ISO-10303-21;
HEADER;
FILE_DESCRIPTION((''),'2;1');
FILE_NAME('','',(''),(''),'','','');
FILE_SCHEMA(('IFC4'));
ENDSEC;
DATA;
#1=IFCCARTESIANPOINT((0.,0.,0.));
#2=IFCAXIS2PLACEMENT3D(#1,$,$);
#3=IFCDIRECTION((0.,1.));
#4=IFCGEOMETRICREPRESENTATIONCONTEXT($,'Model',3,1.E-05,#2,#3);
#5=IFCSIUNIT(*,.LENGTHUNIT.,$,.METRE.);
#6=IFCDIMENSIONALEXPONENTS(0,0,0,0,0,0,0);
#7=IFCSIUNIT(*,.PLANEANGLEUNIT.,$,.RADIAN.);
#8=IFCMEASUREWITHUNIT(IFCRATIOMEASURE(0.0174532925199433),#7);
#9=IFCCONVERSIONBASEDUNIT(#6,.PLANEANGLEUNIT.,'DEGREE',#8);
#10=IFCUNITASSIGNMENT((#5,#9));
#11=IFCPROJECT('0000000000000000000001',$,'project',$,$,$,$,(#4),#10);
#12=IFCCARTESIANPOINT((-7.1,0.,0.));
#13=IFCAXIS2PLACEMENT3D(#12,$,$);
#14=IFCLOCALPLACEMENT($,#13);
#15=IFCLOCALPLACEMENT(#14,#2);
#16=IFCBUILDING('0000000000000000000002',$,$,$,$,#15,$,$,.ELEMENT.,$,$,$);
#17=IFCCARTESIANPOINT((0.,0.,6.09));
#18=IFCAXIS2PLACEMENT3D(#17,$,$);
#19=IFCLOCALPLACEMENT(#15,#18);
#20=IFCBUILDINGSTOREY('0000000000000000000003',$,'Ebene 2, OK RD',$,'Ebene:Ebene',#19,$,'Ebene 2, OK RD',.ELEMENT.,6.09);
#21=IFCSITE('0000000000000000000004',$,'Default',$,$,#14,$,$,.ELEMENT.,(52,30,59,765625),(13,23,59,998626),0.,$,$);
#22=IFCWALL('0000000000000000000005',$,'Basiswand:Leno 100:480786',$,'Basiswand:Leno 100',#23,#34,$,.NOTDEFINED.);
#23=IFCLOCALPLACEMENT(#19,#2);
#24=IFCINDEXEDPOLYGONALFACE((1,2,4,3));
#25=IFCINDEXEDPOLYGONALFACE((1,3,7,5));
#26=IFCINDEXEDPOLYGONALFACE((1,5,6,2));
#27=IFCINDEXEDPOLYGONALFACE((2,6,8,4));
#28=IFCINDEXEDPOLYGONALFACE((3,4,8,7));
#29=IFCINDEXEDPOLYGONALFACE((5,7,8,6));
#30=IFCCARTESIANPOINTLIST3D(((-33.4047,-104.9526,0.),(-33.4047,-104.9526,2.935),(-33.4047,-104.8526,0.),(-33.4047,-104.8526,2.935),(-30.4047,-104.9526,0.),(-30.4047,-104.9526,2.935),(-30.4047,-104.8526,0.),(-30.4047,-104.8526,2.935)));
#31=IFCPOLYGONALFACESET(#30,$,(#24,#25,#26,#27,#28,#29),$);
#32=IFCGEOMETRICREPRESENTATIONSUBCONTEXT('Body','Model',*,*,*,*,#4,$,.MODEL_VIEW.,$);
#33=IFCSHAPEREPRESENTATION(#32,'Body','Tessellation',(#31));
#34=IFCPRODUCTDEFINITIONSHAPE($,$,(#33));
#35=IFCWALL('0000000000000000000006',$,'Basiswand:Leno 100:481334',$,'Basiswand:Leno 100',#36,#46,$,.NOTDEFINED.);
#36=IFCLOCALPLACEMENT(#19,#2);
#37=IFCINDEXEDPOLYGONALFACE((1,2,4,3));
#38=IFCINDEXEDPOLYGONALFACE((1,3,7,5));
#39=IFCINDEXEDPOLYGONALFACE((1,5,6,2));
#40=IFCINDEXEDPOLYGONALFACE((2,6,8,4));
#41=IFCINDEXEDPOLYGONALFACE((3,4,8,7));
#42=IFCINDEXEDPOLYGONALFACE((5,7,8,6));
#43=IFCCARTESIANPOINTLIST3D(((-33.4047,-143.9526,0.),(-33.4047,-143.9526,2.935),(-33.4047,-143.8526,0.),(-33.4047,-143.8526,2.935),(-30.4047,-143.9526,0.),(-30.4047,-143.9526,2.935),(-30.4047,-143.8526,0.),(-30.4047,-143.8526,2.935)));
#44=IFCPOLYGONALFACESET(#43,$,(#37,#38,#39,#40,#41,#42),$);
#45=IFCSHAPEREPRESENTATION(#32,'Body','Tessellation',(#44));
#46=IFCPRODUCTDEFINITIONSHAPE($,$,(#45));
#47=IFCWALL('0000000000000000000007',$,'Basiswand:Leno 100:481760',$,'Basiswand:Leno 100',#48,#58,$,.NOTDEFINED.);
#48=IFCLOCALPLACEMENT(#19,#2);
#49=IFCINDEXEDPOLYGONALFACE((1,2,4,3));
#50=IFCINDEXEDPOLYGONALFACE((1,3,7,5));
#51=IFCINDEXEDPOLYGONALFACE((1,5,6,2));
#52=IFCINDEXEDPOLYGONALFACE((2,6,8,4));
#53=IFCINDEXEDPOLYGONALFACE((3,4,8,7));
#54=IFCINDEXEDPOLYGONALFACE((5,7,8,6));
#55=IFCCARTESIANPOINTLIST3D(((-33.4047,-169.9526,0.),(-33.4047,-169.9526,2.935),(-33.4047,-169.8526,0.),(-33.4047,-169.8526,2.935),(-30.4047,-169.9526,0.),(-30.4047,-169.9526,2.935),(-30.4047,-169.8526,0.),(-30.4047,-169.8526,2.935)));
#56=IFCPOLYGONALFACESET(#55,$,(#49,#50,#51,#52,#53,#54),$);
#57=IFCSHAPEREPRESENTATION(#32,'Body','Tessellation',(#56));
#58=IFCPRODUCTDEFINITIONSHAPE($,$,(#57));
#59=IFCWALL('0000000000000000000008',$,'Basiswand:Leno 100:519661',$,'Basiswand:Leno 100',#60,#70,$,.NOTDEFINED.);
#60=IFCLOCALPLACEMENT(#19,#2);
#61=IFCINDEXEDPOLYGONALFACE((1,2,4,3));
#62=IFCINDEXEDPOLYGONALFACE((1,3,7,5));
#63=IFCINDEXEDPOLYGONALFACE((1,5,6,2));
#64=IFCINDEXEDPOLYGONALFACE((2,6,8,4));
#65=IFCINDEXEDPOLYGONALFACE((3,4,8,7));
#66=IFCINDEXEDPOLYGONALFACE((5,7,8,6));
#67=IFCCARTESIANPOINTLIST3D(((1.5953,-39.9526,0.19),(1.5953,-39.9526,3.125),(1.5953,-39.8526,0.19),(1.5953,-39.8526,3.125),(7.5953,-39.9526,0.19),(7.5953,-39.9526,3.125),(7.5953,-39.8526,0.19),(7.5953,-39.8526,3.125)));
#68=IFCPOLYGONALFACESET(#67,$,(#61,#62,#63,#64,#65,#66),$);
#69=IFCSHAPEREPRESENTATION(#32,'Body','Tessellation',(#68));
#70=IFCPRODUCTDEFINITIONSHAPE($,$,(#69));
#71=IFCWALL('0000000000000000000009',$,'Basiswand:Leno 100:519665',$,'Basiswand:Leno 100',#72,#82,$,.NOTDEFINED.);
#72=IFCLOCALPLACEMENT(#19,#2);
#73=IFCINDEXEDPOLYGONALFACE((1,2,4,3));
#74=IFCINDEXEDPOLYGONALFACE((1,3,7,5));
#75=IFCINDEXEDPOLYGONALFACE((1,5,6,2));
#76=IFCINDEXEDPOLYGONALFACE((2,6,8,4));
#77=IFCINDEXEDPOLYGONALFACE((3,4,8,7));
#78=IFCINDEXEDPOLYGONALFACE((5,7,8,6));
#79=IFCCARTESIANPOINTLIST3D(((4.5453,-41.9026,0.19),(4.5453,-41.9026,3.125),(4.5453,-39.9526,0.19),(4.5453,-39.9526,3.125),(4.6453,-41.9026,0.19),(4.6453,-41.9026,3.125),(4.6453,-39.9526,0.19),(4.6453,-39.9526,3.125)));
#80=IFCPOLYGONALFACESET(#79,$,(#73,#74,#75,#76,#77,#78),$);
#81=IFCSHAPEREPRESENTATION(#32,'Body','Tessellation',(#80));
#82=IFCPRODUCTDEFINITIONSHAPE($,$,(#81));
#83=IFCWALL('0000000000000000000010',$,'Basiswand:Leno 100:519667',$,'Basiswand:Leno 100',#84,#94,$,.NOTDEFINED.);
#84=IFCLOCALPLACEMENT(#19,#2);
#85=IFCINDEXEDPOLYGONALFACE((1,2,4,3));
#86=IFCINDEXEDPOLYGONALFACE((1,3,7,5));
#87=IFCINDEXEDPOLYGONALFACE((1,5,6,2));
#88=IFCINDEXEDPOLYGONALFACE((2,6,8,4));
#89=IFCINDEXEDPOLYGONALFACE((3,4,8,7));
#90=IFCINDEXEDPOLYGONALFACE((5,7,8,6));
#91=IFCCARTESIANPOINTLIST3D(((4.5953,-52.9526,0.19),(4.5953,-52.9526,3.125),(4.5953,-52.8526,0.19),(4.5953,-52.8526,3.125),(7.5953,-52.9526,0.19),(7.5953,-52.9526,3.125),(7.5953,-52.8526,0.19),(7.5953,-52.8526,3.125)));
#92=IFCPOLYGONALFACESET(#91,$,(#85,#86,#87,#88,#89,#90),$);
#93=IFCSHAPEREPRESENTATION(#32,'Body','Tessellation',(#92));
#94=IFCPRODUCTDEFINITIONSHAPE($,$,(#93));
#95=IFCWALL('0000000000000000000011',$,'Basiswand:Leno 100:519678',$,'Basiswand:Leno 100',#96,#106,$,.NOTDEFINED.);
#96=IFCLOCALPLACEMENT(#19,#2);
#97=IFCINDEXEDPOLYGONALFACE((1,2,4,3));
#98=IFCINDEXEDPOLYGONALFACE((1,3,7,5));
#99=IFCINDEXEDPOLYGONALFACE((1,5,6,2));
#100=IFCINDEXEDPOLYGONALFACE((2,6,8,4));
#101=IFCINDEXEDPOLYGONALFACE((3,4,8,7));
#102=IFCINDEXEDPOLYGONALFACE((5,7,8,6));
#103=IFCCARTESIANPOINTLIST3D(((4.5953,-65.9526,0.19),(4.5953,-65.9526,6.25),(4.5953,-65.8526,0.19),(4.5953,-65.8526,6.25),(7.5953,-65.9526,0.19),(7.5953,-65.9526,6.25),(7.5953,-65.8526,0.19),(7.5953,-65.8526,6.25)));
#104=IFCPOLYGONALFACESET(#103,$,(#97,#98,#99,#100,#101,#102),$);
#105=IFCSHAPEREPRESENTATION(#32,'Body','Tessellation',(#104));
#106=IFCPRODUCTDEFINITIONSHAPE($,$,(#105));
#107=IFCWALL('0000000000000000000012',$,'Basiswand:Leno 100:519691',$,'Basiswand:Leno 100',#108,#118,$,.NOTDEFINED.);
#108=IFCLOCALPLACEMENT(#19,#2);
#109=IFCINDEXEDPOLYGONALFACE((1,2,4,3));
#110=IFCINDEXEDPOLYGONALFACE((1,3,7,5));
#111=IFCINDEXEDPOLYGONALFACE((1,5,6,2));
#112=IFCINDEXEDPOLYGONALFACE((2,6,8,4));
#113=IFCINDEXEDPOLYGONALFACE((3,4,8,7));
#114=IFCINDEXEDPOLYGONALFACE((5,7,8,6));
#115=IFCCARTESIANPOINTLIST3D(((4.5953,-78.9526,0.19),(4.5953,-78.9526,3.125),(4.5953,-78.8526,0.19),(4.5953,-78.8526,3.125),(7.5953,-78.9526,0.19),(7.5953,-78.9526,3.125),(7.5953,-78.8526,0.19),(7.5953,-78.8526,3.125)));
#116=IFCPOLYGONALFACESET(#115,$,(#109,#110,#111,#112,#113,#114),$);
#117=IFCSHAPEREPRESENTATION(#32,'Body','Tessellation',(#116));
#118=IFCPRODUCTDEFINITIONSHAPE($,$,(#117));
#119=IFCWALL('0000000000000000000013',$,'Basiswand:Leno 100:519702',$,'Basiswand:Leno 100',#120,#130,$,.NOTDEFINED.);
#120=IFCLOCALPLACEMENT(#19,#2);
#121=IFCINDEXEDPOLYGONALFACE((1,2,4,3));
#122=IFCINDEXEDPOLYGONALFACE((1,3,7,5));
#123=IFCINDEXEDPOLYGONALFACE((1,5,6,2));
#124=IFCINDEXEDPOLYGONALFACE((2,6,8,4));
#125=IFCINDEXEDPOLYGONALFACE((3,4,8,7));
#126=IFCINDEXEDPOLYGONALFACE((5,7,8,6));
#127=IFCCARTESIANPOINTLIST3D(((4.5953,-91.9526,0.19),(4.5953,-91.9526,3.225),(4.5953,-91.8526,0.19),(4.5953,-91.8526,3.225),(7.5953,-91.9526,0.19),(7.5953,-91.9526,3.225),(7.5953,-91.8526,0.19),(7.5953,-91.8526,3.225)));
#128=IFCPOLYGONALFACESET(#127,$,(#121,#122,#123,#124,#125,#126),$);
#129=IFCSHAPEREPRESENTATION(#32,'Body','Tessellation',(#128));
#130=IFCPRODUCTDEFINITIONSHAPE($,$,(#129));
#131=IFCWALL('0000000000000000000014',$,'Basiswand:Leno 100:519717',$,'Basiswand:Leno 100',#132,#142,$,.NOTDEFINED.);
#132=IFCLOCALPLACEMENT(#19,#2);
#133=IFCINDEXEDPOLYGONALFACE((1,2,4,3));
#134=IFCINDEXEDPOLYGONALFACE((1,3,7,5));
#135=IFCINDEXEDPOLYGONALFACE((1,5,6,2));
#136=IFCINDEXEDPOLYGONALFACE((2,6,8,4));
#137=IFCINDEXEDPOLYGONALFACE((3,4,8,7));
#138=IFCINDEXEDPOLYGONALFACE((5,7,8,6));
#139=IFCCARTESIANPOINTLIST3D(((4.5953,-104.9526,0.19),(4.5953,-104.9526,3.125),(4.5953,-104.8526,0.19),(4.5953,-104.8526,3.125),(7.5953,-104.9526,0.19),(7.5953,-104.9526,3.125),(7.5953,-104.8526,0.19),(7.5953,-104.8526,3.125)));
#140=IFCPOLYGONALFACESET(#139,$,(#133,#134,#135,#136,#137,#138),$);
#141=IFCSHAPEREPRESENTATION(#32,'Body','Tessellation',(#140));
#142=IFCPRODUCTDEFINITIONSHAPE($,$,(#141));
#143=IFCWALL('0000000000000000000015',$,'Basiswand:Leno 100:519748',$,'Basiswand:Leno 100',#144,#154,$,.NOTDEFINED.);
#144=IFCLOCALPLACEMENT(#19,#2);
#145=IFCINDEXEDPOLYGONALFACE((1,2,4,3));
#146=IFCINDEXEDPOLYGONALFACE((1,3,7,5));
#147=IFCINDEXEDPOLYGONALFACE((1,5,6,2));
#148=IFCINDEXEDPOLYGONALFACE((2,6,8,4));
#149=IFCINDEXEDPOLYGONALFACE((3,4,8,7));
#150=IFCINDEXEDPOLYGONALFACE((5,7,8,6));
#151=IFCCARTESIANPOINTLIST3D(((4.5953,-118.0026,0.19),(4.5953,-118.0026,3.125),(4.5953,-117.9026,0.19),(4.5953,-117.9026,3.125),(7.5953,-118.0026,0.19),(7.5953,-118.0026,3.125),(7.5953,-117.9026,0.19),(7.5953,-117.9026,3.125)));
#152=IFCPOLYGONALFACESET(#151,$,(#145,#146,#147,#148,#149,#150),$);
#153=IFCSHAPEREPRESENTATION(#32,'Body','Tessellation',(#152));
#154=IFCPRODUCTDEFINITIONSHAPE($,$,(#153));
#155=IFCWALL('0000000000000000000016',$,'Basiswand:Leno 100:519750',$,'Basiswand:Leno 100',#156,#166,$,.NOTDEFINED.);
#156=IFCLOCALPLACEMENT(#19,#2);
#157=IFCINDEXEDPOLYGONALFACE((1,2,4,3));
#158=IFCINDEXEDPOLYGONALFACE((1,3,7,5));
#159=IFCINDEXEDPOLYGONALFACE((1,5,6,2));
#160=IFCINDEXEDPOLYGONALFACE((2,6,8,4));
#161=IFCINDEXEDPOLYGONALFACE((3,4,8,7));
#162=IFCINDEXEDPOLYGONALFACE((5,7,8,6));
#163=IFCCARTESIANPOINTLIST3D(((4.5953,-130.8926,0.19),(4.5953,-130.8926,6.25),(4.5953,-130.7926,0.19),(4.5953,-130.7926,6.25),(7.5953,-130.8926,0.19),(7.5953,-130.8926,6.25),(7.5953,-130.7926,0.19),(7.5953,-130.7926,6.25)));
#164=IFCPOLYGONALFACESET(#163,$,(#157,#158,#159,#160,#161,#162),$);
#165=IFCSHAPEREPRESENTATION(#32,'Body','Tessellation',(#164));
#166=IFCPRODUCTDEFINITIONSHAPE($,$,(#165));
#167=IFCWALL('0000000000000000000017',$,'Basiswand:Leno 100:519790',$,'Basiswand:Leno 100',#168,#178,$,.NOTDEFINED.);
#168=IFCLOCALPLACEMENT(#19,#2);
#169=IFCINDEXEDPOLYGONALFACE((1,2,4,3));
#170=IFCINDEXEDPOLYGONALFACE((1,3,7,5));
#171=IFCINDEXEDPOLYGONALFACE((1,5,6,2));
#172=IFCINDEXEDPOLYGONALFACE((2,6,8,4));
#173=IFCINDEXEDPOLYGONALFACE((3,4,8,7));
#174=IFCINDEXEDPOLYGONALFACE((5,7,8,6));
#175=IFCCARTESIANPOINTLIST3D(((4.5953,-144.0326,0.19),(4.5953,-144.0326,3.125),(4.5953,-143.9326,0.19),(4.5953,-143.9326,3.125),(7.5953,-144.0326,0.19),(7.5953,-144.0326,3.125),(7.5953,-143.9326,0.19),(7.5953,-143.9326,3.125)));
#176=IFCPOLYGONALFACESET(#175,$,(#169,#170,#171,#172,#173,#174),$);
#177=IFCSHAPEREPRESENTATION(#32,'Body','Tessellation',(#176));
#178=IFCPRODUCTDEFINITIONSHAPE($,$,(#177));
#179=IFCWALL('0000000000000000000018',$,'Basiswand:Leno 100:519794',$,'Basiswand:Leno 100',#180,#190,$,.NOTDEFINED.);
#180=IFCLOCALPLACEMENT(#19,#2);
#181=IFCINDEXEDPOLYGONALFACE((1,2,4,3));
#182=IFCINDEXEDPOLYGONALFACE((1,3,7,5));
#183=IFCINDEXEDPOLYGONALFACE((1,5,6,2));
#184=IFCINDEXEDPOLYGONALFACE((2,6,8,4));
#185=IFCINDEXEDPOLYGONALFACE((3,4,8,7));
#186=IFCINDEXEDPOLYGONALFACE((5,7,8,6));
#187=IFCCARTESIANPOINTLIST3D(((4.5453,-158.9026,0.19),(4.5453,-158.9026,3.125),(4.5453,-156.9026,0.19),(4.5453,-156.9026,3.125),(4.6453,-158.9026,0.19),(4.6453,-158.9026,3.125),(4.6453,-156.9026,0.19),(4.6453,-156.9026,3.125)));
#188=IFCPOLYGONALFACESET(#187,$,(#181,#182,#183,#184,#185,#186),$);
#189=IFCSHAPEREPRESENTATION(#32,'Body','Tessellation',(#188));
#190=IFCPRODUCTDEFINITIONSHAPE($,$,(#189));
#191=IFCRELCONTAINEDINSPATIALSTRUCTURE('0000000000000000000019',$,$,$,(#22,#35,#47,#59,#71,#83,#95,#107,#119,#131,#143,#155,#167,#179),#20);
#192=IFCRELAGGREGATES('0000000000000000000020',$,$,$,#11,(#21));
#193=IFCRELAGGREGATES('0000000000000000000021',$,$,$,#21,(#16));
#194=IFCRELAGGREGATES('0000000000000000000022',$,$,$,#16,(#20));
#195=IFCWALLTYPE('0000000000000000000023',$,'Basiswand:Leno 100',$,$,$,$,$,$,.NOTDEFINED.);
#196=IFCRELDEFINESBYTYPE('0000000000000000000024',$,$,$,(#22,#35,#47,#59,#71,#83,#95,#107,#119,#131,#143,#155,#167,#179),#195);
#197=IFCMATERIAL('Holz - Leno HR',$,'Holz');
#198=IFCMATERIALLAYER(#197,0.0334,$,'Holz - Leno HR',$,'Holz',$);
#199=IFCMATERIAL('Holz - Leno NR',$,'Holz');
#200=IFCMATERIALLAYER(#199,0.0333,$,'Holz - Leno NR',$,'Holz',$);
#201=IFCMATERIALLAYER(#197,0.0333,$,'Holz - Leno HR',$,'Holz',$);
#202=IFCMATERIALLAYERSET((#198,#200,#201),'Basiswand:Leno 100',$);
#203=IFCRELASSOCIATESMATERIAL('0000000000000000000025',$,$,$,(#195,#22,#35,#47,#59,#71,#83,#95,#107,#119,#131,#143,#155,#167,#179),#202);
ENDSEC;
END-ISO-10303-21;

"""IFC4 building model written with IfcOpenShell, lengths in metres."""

from ifc_helpers import new_model, entity, si_unit, converted_unit, direction, frame, origin, place, context, subcontext, project, spatial, indexed_curve, outline, extrude, material, layer, layer_set, type_object, element, save


model = new_model("IFC4")

# Units and contexts
model_context = context("Model", 3, precision=1e-05, world=origin(), true_north=direction((0.0, 1.0)))
body_context = subcontext(model_context, "Body", "Model", "MODEL_VIEW")
ifc_project = project(units=[si_unit("LENGTHUNIT", "METRE"), converted_unit("PLANEANGLEUNIT", "DEGREE", entity("IfcRatioMeasure", 0.0174532925199433), si_unit("PLANEANGLEUNIT", "RADIAN"), dimensions=[0, 0, 0, 0, 0, 0, 0])], contexts=[model_context])

# Site, building, storey
site_placement = place(None, frame((-7.1, 0.0, 0.0)))
site = spatial("IfcSite", under=ifc_project, at=site_placement, Name="Default", CompositionType="ELEMENT", RefLatitude=(52, 30, 59, 765625), RefLongitude=(13, 23, 59, 998626), RefElevation=0.0)
building_placement = place(site_placement, origin())
building = spatial("IfcBuilding", under=site, at=building_placement, CompositionType="ELEMENT")
storey_placement = place(building_placement, frame((0.0, 0.0, 6.09)))
storey = spatial("IfcBuildingStorey", under=building, at=storey_placement, Name="Ebene 2, OK RD", ObjectType="Ebene:Ebene", LongName="Ebene 2, OK RD", CompositionType="ELEMENT", Elevation=6.09)

# Walls
ifc_material_1 = material(Name="Holz - Leno HR", Category="Holz")
ifc_layer_1 = layer(ifc_material_1, 0.0334, Name="Holz - Leno HR", Category="Holz")
ifc_material_2 = material(Name="Holz - Leno NR", Category="Holz")
ifc_layer_2 = layer(ifc_material_2, 0.0333, Name="Holz - Leno NR", Category="Holz")
ifc_layer_3 = layer(ifc_material_1, 0.0333, Name="Holz - Leno HR", Category="Holz")
ifc_layer_set = layer_set([ifc_layer_1, ifc_layer_2, ifc_layer_3], Name="Basiswand:Leno 100")
wall_type = type_object("IfcWallType", Name="Basiswand:Leno 100", PredefinedType="NOTDEFINED", material=ifc_layer_set)
for number, where, z_axis, x_axis, name in (
    (1, (-30.4047, -104.9026, 0.0), (0.0, 0.0, 1.0), (-1.0, 0.0, 0.0), "Basiswand:Leno 100:480786"),
    (2, (-30.4047, -143.9026, 0.0), (0.0, 0.0, 1.0), (-1.0, 0.0, 0.0), "Basiswand:Leno 100:481334"),
):
    element("IfcWall", number, at=place(storey_placement, frame(where, z_axis=z_axis, x_axis=x_axis)), inside=storey, type_object=wall_type, material=ifc_layer_set, Name=name, ObjectType="Basiswand:Leno 100", PredefinedType="NOTDEFINED", context=body_context, shape_type="SweptSolid", body=[
        extrude(outline(indexed_curve([(3.0, 0.05), (0.0, 0.05), (0.0, -0.05), (3.0, -0.05), (3.0, 0.05)], self_intersect=False)), origin(), (0.0, 0.0, 1.0), 2.935),
    ])
wall_1_placement = place(storey_placement, frame((-30.4047, -169.9026, 0.0), z_axis=(0.0, 0.0, 1.0), x_axis=(-1.0, 0.0, 0.0)))
element("IfcWall", 3, at=wall_1_placement, inside=storey, type_object=wall_type, material=ifc_layer_set, Name="Basiswand:Leno 100:481760", ObjectType="Basiswand:Leno 100", PredefinedType="NOTDEFINED", context=body_context, shape_type="SweptSolid", body=[
    extrude(outline(indexed_curve([(3.0, 0.05), (0.0, 0.05), (0.0, -0.05), (3.0, -0.05), (3.0, 0.05)], self_intersect=False)), origin(), (0.0, 0.0, 1.0), 2.935),
])
wall_2_placement = place(storey_placement, frame((1.5953, -39.9026, 0.19)))
element("IfcWall", 4, at=wall_2_placement, inside=storey, type_object=wall_type, material=ifc_layer_set, Name="Basiswand:Leno 100:519661", ObjectType="Basiswand:Leno 100", PredefinedType="NOTDEFINED", context=body_context, shape_type="SweptSolid", body=[
    extrude(outline(indexed_curve([(6.0, 0.05), (0.0, 0.05), (0.0, -0.05), (6.0, -0.05), (6.0, 0.05)], self_intersect=False)), origin(), (0.0, 0.0, 1.0), 2.935),
])
wall_3_placement = place(storey_placement, frame((4.5953, -41.9026, 0.19), z_axis=(0.0, 0.0, 1.0), x_axis=(0.0, 1.0, 0.0)))
element("IfcWall", 5, at=wall_3_placement, inside=storey, type_object=wall_type, material=ifc_layer_set, Name="Basiswand:Leno 100:519665", ObjectType="Basiswand:Leno 100", PredefinedType="NOTDEFINED", context=body_context, shape_type="SweptSolid", body=[
    extrude(outline(indexed_curve([(1.95, 0.05), (0.0, 0.05), (0.0, -0.05), (1.95, -0.05), (1.95, 0.05)], self_intersect=False)), origin(), (0.0, 0.0, 1.0), 2.935),
])
wall_4_placement = place(storey_placement, frame((7.5953, -52.9026, 0.19), z_axis=(0.0, 0.0, 1.0), x_axis=(-1.0, 0.0, 0.0)))
element("IfcWall", 6, at=wall_4_placement, inside=storey, type_object=wall_type, material=ifc_layer_set, Name="Basiswand:Leno 100:519667", ObjectType="Basiswand:Leno 100", PredefinedType="NOTDEFINED", context=body_context, shape_type="SweptSolid", body=[
    extrude(outline(indexed_curve([(3.0, 0.05), (0.0, 0.05), (0.0, -0.05), (3.0, -0.05), (3.0, 0.05)], self_intersect=False)), origin(), (0.0, 0.0, 1.0), 2.935),
])
wall_5_placement = place(storey_placement, frame((7.5953, -65.9026, 0.19), z_axis=(0.0, 0.0, 1.0), x_axis=(-1.0, 0.0, 0.0)))
element("IfcWall", 7, at=wall_5_placement, inside=storey, type_object=wall_type, material=ifc_layer_set, Name="Basiswand:Leno 100:519678", ObjectType="Basiswand:Leno 100", PredefinedType="NOTDEFINED", context=body_context, shape_type="SweptSolid", body=[
    extrude(outline(indexed_curve([(3.0, 0.05), (0.0, 0.05), (0.0, -0.05), (3.0, -0.05), (3.0, 0.05)], self_intersect=False)), origin(), (0.0, 0.0, 1.0), 6.06),
])
wall_6_placement = place(storey_placement, frame((7.5953, -78.9026, 0.19), z_axis=(0.0, 0.0, 1.0), x_axis=(-1.0, 0.0, 0.0)))
element("IfcWall", 8, at=wall_6_placement, inside=storey, type_object=wall_type, material=ifc_layer_set, Name="Basiswand:Leno 100:519691", ObjectType="Basiswand:Leno 100", PredefinedType="NOTDEFINED", context=body_context, shape_type="SweptSolid", body=[
    extrude(outline(indexed_curve([(3.0, 0.05), (0.0, 0.05), (0.0, -0.05), (3.0, -0.05), (3.0, 0.05)], self_intersect=False)), origin(), (0.0, 0.0, 1.0), 2.935),
])
wall_7_placement = place(storey_placement, frame((7.5953, -91.9026, 0.19), z_axis=(0.0, 0.0, 1.0), x_axis=(-1.0, 0.0, 0.0)))
element("IfcWall", 9, at=wall_7_placement, inside=storey, type_object=wall_type, material=ifc_layer_set, Name="Basiswand:Leno 100:519702", ObjectType="Basiswand:Leno 100", PredefinedType="NOTDEFINED", context=body_context, shape_type="SweptSolid", body=[
    extrude(outline(indexed_curve([(3.0, 0.05), (0.0, 0.05), (0.0, -0.05), (3.0, -0.05), (3.0, 0.05)], self_intersect=False)), origin(), (0.0, 0.0, 1.0), 3.035),
])
for number, where, z_axis, x_axis, name in (
    (10, (7.5953, -104.9026, 0.19), (0.0, 0.0, 1.0), (-1.0, 0.0, 0.0), "Basiswand:Leno 100:519717"),
    (11, (7.5953, -117.9526, 0.19), (0.0, 0.0, 1.0), (-1.0, 0.0, 0.0), "Basiswand:Leno 100:519748"),
):
    element("IfcWall", number, at=place(storey_placement, frame(where, z_axis=z_axis, x_axis=x_axis)), inside=storey, type_object=wall_type, material=ifc_layer_set, Name=name, ObjectType="Basiswand:Leno 100", PredefinedType="NOTDEFINED", context=body_context, shape_type="SweptSolid", body=[
        extrude(outline(indexed_curve([(3.0, 0.05), (0.0, 0.05), (0.0, -0.05), (3.0, -0.05), (3.0, 0.05)], self_intersect=False)), origin(), (0.0, 0.0, 1.0), 2.935),
    ])
wall_8_placement = place(storey_placement, frame((7.5953, -130.8426, 0.19), z_axis=(0.0, 0.0, 1.0), x_axis=(-1.0, 0.0, 0.0)))
element("IfcWall", 12, at=wall_8_placement, inside=storey, type_object=wall_type, material=ifc_layer_set, Name="Basiswand:Leno 100:519750", ObjectType="Basiswand:Leno 100", PredefinedType="NOTDEFINED", context=body_context, shape_type="SweptSolid", body=[
    extrude(outline(indexed_curve([(3.0, 0.05), (0.0, 0.05), (0.0, -0.05), (3.0, -0.05), (3.0, 0.05)], self_intersect=False)), origin(), (0.0, 0.0, 1.0), 6.06),
])
wall_9_placement = place(storey_placement, frame((7.5953, -143.9826, 0.19), z_axis=(0.0, 0.0, 1.0), x_axis=(-1.0, 0.0, 0.0)))
element("IfcWall", 13, at=wall_9_placement, inside=storey, type_object=wall_type, material=ifc_layer_set, Name="Basiswand:Leno 100:519790", ObjectType="Basiswand:Leno 100", PredefinedType="NOTDEFINED", context=body_context, shape_type="SweptSolid", body=[
    extrude(outline(indexed_curve([(3.0, 0.05), (0.0, 0.05), (0.0, -0.05), (3.0, -0.05), (3.0, 0.05)], self_intersect=False)), origin(), (0.0, 0.0, 1.0), 2.935),
])
wall_10_placement = place(storey_placement, frame((4.5953, -158.9026, 0.19), z_axis=(0.0, 0.0, 1.0), x_axis=(0.0, 1.0, 0.0)))
element("IfcWall", 14, at=wall_10_placement, inside=storey, type_object=wall_type, material=ifc_layer_set, Name="Basiswand:Leno 100:519794", ObjectType="Basiswand:Leno 100", PredefinedType="NOTDEFINED", context=body_context, shape_type="SweptSolid", body=[
    extrude(outline(indexed_curve([(2.0, 0.05), (0.0, 0.05), (0.0, -0.05), (2.0, -0.05), (2.0, 0.05)], self_intersect=False)), origin(), (0.0, 0.0, 1.0), 2.935),
])

save(model, "model.ifc")
